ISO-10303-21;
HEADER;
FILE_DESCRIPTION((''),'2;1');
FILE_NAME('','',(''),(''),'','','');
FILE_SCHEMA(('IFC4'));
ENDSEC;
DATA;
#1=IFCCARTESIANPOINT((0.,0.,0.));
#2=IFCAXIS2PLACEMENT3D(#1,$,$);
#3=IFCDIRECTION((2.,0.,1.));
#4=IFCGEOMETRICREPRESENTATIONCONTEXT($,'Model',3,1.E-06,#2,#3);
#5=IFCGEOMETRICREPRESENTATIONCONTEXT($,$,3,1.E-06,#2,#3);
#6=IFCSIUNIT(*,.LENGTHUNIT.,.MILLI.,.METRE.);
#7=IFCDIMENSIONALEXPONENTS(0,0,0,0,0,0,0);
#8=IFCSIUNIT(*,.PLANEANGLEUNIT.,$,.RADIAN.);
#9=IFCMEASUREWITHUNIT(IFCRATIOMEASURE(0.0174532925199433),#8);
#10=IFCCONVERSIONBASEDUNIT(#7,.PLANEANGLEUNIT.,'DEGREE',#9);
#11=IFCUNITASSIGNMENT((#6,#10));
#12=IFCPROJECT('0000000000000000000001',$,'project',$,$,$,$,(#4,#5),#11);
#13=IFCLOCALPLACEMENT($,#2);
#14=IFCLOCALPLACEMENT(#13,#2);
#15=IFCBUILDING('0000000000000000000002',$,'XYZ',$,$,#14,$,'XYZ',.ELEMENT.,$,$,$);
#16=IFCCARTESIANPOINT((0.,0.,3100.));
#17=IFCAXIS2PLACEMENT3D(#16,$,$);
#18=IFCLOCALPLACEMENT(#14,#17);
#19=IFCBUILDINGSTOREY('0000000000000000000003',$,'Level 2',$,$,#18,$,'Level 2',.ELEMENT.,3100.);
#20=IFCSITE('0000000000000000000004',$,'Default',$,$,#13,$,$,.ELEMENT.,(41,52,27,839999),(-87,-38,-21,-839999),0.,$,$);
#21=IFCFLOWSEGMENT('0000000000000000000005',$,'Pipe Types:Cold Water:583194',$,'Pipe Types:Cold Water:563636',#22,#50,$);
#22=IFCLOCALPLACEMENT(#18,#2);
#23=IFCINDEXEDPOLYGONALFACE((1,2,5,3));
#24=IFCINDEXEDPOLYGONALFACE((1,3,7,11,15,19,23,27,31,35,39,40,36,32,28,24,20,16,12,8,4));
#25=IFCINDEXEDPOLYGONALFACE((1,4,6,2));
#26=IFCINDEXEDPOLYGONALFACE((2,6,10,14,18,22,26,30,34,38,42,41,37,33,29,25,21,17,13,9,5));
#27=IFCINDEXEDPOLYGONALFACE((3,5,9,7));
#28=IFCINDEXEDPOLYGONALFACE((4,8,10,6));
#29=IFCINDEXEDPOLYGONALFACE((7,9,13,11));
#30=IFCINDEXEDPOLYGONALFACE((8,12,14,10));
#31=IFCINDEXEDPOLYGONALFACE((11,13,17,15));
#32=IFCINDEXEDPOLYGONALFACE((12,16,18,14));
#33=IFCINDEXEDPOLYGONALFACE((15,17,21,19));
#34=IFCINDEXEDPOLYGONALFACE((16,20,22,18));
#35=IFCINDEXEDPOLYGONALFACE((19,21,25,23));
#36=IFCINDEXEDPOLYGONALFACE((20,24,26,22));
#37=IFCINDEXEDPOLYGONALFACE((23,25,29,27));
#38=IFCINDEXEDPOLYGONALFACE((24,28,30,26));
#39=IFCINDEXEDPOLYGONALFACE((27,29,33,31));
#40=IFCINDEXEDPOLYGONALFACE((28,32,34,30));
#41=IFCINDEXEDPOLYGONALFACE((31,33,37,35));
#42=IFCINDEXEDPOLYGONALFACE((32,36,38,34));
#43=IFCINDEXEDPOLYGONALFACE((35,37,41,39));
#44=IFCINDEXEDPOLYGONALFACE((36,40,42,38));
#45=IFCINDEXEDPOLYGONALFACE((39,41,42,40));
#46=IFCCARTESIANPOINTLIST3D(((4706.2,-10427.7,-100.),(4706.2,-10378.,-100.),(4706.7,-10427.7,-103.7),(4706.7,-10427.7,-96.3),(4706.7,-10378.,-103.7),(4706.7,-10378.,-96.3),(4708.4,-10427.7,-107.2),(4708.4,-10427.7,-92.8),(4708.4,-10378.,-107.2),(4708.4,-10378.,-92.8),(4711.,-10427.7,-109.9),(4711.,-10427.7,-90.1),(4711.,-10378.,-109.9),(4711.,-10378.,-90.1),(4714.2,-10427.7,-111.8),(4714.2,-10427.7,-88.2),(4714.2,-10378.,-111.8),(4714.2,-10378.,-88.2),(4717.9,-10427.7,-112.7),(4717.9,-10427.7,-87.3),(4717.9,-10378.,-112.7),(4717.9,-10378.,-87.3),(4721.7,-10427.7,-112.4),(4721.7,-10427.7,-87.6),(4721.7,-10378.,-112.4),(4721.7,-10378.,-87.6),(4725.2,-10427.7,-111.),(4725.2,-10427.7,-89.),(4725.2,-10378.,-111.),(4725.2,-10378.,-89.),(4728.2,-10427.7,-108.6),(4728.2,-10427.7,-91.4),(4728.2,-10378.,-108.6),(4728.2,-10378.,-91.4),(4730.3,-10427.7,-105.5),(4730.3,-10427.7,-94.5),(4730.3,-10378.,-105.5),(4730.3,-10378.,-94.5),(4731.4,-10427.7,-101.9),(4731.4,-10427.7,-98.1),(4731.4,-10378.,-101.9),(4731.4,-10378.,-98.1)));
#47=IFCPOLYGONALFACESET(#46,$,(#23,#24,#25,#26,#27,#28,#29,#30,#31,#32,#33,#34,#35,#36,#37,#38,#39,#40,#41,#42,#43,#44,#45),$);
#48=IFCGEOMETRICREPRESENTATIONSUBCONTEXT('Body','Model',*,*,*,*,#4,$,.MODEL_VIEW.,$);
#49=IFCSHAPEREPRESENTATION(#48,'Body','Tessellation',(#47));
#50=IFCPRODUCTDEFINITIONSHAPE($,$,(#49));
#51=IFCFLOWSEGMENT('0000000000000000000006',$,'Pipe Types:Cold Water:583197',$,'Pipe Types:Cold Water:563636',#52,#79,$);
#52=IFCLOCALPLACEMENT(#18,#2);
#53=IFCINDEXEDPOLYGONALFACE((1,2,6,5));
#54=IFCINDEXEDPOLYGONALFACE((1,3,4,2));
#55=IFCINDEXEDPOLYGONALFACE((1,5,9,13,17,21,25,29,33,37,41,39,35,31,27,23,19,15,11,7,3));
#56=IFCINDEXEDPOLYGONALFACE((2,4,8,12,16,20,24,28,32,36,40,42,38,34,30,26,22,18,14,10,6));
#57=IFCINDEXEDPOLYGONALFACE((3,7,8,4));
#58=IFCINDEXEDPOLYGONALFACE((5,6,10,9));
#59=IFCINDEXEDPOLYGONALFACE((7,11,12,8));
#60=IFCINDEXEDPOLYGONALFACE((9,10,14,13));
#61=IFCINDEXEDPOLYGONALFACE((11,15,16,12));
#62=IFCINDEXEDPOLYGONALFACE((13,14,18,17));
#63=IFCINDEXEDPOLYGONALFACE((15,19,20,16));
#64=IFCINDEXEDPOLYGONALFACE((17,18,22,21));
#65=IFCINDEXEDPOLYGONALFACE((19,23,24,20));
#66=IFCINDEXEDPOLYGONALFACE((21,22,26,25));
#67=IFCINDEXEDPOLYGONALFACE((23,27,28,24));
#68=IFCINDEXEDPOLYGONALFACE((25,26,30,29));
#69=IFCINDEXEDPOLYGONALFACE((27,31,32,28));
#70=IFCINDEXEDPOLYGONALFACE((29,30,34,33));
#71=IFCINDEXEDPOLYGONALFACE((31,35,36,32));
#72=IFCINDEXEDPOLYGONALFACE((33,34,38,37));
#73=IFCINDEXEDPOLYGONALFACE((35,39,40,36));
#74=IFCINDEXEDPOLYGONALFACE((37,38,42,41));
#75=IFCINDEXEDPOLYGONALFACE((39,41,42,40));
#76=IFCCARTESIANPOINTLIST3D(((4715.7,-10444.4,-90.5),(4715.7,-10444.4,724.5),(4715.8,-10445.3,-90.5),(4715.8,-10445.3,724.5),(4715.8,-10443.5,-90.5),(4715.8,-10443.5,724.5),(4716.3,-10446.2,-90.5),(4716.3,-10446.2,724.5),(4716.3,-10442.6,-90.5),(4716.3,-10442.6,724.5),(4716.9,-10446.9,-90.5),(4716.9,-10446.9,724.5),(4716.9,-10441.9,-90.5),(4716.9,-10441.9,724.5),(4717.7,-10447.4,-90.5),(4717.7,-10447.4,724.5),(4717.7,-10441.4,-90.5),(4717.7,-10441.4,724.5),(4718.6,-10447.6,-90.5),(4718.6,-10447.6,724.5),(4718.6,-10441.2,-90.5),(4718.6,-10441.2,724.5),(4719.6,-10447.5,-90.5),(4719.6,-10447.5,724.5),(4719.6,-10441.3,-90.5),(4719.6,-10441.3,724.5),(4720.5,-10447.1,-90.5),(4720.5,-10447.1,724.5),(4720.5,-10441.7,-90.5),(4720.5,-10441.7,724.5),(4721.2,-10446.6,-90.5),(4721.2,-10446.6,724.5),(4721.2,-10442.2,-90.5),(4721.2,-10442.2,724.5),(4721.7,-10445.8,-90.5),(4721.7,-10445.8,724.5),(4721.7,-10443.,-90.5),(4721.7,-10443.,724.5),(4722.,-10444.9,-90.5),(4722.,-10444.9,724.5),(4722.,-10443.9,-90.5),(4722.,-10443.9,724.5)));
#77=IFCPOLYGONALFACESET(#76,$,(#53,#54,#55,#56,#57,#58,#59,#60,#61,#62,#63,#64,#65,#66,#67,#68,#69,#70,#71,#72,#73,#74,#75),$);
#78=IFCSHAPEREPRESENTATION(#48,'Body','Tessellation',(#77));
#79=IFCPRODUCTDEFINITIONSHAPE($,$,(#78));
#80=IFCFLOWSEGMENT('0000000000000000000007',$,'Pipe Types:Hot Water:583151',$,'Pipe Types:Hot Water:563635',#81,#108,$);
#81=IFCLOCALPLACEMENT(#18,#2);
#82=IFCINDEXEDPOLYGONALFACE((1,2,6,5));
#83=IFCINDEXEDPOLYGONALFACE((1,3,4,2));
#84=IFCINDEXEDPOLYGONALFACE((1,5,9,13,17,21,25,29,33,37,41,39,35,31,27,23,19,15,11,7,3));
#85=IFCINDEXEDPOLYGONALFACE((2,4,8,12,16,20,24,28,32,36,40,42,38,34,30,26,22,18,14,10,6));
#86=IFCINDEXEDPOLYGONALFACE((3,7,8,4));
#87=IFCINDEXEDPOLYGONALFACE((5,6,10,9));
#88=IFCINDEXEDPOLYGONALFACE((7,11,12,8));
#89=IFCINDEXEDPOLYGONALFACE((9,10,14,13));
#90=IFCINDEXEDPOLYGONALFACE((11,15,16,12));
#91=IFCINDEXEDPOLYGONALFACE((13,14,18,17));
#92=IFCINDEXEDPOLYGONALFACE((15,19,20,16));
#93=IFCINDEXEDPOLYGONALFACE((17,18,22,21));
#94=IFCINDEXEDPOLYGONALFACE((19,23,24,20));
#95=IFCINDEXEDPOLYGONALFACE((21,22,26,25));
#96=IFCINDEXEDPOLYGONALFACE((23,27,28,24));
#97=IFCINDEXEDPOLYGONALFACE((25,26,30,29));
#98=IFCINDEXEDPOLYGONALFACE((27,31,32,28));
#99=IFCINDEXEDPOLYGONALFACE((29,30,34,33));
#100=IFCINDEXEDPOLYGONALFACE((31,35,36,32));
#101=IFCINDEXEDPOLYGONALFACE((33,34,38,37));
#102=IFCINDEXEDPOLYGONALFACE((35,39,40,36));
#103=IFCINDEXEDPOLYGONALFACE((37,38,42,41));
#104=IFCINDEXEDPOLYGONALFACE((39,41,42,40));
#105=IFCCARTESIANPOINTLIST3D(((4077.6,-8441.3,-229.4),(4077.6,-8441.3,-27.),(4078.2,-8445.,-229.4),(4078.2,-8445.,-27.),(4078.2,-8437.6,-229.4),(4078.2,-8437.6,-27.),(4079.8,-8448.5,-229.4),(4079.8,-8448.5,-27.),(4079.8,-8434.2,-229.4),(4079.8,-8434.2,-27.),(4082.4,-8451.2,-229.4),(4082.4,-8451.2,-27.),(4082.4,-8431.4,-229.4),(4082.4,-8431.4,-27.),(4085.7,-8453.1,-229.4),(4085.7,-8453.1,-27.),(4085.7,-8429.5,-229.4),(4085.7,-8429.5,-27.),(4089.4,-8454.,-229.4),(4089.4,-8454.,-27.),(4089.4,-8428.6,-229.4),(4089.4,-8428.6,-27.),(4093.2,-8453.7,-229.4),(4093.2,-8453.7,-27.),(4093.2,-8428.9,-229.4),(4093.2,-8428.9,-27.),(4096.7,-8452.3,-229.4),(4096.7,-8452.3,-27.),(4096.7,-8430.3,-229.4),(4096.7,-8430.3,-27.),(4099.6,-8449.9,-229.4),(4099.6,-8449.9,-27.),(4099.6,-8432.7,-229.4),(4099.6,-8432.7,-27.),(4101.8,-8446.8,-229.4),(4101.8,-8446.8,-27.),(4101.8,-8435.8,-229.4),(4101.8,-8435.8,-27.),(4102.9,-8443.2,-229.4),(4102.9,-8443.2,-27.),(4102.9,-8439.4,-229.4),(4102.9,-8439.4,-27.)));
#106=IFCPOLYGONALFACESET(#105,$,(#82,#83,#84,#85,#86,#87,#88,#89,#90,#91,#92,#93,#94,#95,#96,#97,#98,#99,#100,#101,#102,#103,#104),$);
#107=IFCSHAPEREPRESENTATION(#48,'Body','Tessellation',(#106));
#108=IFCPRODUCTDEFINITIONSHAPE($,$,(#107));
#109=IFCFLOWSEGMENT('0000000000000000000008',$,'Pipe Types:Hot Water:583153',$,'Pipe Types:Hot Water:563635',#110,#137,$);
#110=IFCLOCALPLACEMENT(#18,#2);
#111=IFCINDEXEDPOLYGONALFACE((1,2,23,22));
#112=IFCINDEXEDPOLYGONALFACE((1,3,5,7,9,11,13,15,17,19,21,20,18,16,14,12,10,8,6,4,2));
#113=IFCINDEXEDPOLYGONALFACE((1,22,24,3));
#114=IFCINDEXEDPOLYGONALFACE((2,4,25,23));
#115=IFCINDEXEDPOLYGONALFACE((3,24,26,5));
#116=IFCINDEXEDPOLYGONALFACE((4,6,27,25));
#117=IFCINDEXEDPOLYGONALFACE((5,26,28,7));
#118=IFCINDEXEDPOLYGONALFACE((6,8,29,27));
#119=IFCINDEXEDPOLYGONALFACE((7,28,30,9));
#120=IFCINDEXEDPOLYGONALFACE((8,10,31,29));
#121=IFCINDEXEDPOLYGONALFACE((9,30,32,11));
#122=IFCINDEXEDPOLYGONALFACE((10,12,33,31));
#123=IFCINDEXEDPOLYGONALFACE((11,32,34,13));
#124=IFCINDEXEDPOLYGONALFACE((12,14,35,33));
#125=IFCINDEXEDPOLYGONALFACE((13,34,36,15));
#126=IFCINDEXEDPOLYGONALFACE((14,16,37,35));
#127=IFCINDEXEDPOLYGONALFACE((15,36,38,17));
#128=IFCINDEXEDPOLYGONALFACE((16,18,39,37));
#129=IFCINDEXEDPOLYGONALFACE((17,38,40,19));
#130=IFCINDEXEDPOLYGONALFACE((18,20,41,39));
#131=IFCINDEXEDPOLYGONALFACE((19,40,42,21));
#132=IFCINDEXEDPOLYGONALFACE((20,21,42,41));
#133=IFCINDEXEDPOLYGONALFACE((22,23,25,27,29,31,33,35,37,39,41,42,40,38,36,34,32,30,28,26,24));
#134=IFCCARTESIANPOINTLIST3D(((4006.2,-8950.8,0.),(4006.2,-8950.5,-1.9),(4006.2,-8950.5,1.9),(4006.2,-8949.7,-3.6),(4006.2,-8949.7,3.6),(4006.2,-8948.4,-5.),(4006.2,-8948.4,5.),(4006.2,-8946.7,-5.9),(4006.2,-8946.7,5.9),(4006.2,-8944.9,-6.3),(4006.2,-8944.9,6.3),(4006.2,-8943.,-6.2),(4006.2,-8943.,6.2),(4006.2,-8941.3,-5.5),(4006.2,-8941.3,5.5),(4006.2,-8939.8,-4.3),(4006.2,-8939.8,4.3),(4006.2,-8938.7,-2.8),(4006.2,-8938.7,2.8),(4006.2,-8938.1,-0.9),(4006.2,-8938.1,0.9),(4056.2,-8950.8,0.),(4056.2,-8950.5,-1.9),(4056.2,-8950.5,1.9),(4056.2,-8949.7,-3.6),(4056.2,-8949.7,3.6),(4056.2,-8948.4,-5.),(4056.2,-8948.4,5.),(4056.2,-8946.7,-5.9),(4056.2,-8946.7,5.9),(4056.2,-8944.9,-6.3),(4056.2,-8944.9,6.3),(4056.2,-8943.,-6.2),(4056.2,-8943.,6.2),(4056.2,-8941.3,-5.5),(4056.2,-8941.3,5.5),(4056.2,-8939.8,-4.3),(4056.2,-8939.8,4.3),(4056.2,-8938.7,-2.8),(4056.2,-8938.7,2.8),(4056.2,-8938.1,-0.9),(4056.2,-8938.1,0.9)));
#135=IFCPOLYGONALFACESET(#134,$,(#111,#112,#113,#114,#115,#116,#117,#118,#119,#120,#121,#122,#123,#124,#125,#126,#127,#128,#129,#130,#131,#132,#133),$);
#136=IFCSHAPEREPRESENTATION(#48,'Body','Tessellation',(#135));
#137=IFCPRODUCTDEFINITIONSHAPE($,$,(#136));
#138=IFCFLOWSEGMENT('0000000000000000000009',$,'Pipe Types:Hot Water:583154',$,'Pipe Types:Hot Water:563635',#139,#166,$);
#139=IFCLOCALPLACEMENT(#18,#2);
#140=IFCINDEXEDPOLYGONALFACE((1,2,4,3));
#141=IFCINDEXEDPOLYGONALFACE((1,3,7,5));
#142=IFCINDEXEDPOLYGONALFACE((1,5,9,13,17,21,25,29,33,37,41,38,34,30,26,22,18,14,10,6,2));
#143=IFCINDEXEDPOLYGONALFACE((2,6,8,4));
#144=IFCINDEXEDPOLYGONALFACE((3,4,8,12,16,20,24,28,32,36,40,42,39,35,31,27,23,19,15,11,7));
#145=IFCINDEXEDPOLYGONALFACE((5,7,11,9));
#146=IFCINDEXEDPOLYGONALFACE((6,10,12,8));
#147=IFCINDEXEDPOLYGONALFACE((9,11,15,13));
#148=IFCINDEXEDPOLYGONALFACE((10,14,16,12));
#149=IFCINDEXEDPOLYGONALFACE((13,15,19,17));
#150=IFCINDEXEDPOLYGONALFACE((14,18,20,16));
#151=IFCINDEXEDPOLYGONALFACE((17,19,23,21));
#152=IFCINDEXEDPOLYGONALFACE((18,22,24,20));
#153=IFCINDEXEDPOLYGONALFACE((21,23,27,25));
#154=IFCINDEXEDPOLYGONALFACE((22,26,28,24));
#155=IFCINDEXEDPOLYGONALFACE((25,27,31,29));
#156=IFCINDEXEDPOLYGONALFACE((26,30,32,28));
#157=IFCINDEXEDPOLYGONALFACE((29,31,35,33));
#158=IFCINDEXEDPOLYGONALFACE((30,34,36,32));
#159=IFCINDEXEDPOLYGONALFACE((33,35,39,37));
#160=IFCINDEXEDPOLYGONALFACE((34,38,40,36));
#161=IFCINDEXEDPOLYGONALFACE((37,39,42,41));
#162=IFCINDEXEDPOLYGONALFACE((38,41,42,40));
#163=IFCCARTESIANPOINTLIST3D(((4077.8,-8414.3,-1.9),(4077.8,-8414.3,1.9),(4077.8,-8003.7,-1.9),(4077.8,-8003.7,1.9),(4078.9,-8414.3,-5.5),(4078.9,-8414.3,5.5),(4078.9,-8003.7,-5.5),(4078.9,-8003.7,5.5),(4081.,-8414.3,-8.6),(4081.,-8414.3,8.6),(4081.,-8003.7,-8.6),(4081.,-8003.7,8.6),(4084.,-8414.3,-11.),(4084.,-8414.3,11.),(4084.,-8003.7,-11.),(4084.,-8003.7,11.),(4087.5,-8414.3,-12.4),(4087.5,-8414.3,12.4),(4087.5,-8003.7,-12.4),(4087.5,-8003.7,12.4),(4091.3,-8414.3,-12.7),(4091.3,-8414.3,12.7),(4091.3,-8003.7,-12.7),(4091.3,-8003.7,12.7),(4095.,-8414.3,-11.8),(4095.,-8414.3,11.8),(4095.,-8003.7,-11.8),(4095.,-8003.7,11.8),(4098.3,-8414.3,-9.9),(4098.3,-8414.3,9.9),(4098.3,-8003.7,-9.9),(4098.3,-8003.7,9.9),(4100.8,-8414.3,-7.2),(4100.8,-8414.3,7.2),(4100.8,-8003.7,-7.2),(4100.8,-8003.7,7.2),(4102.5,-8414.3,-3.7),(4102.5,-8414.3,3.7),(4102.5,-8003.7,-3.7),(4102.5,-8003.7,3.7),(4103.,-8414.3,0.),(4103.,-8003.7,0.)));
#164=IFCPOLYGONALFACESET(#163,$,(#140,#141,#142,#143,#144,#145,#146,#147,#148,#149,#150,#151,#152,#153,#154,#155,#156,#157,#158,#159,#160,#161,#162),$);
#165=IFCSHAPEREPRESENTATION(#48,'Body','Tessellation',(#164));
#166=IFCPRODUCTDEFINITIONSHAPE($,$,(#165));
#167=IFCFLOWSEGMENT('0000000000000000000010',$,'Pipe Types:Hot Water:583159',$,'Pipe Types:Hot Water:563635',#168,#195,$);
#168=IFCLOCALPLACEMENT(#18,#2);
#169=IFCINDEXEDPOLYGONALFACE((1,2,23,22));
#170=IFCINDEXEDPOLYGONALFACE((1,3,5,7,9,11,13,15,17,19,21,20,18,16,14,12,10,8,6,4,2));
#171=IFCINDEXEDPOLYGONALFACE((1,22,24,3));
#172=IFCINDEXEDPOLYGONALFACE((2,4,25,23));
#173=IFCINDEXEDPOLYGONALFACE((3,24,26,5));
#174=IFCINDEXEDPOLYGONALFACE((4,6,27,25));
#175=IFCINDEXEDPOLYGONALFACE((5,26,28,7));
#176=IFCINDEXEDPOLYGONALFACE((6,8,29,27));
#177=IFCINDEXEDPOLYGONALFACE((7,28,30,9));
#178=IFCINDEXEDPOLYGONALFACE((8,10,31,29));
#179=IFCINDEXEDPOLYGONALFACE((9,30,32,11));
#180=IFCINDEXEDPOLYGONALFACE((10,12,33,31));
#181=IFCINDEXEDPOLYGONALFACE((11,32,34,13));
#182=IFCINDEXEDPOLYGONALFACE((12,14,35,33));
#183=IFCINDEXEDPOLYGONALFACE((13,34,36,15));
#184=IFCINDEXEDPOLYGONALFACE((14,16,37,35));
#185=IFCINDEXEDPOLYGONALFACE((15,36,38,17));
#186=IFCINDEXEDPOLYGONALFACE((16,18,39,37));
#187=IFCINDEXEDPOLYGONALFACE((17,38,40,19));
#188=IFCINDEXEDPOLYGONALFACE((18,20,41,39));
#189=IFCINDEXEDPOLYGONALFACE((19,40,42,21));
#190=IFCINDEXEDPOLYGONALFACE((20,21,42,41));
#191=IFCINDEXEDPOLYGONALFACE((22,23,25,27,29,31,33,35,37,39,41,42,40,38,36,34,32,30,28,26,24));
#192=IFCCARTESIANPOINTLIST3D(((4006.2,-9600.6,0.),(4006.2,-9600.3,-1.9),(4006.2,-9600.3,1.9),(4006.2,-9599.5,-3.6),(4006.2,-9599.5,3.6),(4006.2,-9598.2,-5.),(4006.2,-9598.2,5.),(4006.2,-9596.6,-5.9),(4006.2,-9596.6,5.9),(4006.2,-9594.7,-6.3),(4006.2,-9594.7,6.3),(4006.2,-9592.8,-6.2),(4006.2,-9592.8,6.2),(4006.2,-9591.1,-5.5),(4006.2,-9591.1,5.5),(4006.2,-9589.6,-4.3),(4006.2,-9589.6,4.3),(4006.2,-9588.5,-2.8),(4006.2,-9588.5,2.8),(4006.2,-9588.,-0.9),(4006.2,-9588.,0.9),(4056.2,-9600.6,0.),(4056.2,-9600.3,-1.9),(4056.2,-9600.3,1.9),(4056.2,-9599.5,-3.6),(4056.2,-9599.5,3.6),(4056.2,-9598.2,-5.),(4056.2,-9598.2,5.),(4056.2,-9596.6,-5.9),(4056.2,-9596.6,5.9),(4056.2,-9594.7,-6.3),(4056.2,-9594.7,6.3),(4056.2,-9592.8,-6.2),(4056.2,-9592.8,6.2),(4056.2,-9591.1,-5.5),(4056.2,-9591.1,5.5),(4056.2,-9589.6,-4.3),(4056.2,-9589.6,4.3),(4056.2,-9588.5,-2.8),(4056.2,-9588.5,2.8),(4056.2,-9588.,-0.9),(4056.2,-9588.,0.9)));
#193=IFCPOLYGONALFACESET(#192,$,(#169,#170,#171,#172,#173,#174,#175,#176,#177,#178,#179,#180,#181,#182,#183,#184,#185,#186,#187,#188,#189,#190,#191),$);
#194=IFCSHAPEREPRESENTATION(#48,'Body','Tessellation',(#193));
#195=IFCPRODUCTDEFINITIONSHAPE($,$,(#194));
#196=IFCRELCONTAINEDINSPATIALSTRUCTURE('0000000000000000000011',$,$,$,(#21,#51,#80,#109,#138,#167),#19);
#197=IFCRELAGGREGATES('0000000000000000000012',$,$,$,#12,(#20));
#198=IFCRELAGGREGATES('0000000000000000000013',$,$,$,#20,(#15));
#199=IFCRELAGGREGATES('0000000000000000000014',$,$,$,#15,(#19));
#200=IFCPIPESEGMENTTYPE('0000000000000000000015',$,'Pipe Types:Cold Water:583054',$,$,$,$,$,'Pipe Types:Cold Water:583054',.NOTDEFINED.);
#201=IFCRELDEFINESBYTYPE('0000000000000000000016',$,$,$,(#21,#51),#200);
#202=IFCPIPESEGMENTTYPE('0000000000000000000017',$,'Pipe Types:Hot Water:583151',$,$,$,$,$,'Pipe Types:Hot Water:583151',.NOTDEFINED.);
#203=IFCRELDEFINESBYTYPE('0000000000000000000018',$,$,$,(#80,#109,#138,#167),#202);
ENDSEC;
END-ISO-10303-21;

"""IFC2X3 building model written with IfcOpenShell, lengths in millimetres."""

from ifc_helpers import new_model, entity, si_unit, converted_unit, direction, frame, frame_2d, origin, origin_2d_with_axis, place, context, subcontext, project, spatial, circle, extrude, type_object, element, save


model = new_model("IFC2X3")

# Units and contexts
model_context = context("Model", 3, precision=1e-06, world=origin(), true_north=direction((2.0, 0.0, 1.0)))
context_of_model = context(None, 3, precision=1e-06, world=origin(), true_north=direction((2.0, 0.0, 1.0)))
body_context = subcontext(model_context, "Body", "Model", "MODEL_VIEW")
ifc_project = project(units=[si_unit("LENGTHUNIT", "METRE", prefix="MILLI"), converted_unit("PLANEANGLEUNIT", "DEGREE", entity("IfcRatioMeasure", 0.0174532925199433), si_unit("PLANEANGLEUNIT", "RADIAN"), dimensions=[0, 0, 0, 0, 0, 0, 0])], contexts=[model_context, context_of_model])

# Site, building, storey
site_placement = place(None, origin())
site = spatial("IfcSite", under=ifc_project, at=site_placement, Name="Default", CompositionType="ELEMENT", RefLatitude=(41, 52, 27, 839999), RefLongitude=(-87, -38, -21, -839999), RefElevation=0.0)
building_placement = place(site_placement, origin())
building = spatial("IfcBuilding", under=site, at=building_placement, Name="XYZ", LongName="XYZ", CompositionType="ELEMENT")
storey_placement = place(building_placement, frame((0.0, 0.0, 3100.0)))
storey = spatial("IfcBuildingStorey", under=building, at=storey_placement, Name="Level 2", LongName="Level 2", CompositionType="ELEMENT", Elevation=3100.0)

# Flow segments
pipe_segment_type_1 = type_object("IfcPipeSegmentType", Name="Pipe Types:Cold Water:583054", ElementType="Pipe Types:Cold Water:583054", PredefinedType="NOTDEFINED")
flow_segment_1_placement = place(storey_placement, origin())
element("IfcFlowSegment", 1, at=flow_segment_1_placement, inside=storey, type_object=pipe_segment_type_1, Name="Pipe Types:Cold Water:583194", ObjectType="Pipe Types:Cold Water:563636", context=body_context, shape_type="SweptSolid", body=[
    extrude(circle(Radius=12.7, at=origin_2d_with_axis()), frame((4718.9, -10427.7, -100.0), z_axis=(0.0, 1.0, 0.0), x_axis=(-1.0, 0.0, 0.0)), (0.0, 0.0, 1.0), 49.7),
])
flow_segment_2_placement = place(storey_placement, origin())
element("IfcFlowSegment", 2, at=flow_segment_2_placement, inside=storey, type_object=pipe_segment_type_1, Name="Pipe Types:Cold Water:583197", ObjectType="Pipe Types:Cold Water:563636", context=body_context, shape_type="SweptSolid", body=[
    extrude(circle(Radius=3.2, at=frame_2d((0.0, 0.0), x_axis=(1.0, 0.0))), frame((4718.9, -10444.4, -90.5), z_axis=(0.0, 0.0, 1.0), x_axis=(-1.0, 0.0, 0.0)), (0.0, 0.0, 1.0), 814.9),
])
pipe_segment_type_2 = type_object("IfcPipeSegmentType", Name="Pipe Types:Hot Water:583151", ElementType="Pipe Types:Hot Water:583151", PredefinedType="NOTDEFINED")
flow_segment_3_placement = place(storey_placement, origin())
element("IfcFlowSegment", 3, at=flow_segment_3_placement, inside=storey, type_object=pipe_segment_type_2, Name="Pipe Types:Hot Water:583151", ObjectType="Pipe Types:Hot Water:563635", context=body_context, shape_type="SweptSolid", body=[
    extrude(circle(Radius=12.7, at=frame_2d((0.0, 0.0), x_axis=(1.0, 0.0))), frame((4090.3, -8441.3, -229.4), z_axis=(0.0, 0.0, 1.0), x_axis=(-1.0, 0.0, 0.0)), (0.0, 0.0, 1.0), 202.4),
])
flow_segment_4_placement = place(storey_placement, origin())
element("IfcFlowSegment", 4, at=flow_segment_4_placement, inside=storey, type_object=pipe_segment_type_2, Name="Pipe Types:Hot Water:583153", ObjectType="Pipe Types:Hot Water:563635", context=body_context, shape_type="SweptSolid", body=[
    extrude(circle(Radius=6.3, at=origin_2d_with_axis()), frame((4006.2, -8944.4, 0.0), z_axis=(1.0, 0.0, 0.0), x_axis=(0.0, -1.0, 0.0)), (0.0, 0.0, 1.0), 50.0),
])
flow_segment_5_placement = place(storey_placement, origin())
element("IfcFlowSegment", 5, at=flow_segment_5_placement, inside=storey, type_object=pipe_segment_type_2, Name="Pipe Types:Hot Water:583154", ObjectType="Pipe Types:Hot Water:563635", context=body_context, shape_type="SweptSolid", body=[
    extrude(circle(Radius=12.7, at=frame_2d((0.0, 0.0), x_axis=(1.0, 0.0))), frame((4090.3, -8414.3, 0.0), z_axis=(0.0, 1.0, 0.0), x_axis=(1.0, 0.0, 0.0)), (0.0, 0.0, 1.0), 410.6),
])
flow_segment_6_placement = place(storey_placement, origin())
element("IfcFlowSegment", 6, at=flow_segment_6_placement, inside=storey, type_object=pipe_segment_type_2, Name="Pipe Types:Hot Water:583159", ObjectType="Pipe Types:Hot Water:563635", context=body_context, shape_type="SweptSolid", body=[
    extrude(circle(Radius=6.3, at=origin_2d_with_axis()), frame((4006.2, -9594.3, 0.0), z_axis=(1.0, 0.0, 0.0), x_axis=(0.0, -1.0, 0.0)), (0.0, 0.0, 1.0), 50.0),
])

save(model, "model.ifc")
